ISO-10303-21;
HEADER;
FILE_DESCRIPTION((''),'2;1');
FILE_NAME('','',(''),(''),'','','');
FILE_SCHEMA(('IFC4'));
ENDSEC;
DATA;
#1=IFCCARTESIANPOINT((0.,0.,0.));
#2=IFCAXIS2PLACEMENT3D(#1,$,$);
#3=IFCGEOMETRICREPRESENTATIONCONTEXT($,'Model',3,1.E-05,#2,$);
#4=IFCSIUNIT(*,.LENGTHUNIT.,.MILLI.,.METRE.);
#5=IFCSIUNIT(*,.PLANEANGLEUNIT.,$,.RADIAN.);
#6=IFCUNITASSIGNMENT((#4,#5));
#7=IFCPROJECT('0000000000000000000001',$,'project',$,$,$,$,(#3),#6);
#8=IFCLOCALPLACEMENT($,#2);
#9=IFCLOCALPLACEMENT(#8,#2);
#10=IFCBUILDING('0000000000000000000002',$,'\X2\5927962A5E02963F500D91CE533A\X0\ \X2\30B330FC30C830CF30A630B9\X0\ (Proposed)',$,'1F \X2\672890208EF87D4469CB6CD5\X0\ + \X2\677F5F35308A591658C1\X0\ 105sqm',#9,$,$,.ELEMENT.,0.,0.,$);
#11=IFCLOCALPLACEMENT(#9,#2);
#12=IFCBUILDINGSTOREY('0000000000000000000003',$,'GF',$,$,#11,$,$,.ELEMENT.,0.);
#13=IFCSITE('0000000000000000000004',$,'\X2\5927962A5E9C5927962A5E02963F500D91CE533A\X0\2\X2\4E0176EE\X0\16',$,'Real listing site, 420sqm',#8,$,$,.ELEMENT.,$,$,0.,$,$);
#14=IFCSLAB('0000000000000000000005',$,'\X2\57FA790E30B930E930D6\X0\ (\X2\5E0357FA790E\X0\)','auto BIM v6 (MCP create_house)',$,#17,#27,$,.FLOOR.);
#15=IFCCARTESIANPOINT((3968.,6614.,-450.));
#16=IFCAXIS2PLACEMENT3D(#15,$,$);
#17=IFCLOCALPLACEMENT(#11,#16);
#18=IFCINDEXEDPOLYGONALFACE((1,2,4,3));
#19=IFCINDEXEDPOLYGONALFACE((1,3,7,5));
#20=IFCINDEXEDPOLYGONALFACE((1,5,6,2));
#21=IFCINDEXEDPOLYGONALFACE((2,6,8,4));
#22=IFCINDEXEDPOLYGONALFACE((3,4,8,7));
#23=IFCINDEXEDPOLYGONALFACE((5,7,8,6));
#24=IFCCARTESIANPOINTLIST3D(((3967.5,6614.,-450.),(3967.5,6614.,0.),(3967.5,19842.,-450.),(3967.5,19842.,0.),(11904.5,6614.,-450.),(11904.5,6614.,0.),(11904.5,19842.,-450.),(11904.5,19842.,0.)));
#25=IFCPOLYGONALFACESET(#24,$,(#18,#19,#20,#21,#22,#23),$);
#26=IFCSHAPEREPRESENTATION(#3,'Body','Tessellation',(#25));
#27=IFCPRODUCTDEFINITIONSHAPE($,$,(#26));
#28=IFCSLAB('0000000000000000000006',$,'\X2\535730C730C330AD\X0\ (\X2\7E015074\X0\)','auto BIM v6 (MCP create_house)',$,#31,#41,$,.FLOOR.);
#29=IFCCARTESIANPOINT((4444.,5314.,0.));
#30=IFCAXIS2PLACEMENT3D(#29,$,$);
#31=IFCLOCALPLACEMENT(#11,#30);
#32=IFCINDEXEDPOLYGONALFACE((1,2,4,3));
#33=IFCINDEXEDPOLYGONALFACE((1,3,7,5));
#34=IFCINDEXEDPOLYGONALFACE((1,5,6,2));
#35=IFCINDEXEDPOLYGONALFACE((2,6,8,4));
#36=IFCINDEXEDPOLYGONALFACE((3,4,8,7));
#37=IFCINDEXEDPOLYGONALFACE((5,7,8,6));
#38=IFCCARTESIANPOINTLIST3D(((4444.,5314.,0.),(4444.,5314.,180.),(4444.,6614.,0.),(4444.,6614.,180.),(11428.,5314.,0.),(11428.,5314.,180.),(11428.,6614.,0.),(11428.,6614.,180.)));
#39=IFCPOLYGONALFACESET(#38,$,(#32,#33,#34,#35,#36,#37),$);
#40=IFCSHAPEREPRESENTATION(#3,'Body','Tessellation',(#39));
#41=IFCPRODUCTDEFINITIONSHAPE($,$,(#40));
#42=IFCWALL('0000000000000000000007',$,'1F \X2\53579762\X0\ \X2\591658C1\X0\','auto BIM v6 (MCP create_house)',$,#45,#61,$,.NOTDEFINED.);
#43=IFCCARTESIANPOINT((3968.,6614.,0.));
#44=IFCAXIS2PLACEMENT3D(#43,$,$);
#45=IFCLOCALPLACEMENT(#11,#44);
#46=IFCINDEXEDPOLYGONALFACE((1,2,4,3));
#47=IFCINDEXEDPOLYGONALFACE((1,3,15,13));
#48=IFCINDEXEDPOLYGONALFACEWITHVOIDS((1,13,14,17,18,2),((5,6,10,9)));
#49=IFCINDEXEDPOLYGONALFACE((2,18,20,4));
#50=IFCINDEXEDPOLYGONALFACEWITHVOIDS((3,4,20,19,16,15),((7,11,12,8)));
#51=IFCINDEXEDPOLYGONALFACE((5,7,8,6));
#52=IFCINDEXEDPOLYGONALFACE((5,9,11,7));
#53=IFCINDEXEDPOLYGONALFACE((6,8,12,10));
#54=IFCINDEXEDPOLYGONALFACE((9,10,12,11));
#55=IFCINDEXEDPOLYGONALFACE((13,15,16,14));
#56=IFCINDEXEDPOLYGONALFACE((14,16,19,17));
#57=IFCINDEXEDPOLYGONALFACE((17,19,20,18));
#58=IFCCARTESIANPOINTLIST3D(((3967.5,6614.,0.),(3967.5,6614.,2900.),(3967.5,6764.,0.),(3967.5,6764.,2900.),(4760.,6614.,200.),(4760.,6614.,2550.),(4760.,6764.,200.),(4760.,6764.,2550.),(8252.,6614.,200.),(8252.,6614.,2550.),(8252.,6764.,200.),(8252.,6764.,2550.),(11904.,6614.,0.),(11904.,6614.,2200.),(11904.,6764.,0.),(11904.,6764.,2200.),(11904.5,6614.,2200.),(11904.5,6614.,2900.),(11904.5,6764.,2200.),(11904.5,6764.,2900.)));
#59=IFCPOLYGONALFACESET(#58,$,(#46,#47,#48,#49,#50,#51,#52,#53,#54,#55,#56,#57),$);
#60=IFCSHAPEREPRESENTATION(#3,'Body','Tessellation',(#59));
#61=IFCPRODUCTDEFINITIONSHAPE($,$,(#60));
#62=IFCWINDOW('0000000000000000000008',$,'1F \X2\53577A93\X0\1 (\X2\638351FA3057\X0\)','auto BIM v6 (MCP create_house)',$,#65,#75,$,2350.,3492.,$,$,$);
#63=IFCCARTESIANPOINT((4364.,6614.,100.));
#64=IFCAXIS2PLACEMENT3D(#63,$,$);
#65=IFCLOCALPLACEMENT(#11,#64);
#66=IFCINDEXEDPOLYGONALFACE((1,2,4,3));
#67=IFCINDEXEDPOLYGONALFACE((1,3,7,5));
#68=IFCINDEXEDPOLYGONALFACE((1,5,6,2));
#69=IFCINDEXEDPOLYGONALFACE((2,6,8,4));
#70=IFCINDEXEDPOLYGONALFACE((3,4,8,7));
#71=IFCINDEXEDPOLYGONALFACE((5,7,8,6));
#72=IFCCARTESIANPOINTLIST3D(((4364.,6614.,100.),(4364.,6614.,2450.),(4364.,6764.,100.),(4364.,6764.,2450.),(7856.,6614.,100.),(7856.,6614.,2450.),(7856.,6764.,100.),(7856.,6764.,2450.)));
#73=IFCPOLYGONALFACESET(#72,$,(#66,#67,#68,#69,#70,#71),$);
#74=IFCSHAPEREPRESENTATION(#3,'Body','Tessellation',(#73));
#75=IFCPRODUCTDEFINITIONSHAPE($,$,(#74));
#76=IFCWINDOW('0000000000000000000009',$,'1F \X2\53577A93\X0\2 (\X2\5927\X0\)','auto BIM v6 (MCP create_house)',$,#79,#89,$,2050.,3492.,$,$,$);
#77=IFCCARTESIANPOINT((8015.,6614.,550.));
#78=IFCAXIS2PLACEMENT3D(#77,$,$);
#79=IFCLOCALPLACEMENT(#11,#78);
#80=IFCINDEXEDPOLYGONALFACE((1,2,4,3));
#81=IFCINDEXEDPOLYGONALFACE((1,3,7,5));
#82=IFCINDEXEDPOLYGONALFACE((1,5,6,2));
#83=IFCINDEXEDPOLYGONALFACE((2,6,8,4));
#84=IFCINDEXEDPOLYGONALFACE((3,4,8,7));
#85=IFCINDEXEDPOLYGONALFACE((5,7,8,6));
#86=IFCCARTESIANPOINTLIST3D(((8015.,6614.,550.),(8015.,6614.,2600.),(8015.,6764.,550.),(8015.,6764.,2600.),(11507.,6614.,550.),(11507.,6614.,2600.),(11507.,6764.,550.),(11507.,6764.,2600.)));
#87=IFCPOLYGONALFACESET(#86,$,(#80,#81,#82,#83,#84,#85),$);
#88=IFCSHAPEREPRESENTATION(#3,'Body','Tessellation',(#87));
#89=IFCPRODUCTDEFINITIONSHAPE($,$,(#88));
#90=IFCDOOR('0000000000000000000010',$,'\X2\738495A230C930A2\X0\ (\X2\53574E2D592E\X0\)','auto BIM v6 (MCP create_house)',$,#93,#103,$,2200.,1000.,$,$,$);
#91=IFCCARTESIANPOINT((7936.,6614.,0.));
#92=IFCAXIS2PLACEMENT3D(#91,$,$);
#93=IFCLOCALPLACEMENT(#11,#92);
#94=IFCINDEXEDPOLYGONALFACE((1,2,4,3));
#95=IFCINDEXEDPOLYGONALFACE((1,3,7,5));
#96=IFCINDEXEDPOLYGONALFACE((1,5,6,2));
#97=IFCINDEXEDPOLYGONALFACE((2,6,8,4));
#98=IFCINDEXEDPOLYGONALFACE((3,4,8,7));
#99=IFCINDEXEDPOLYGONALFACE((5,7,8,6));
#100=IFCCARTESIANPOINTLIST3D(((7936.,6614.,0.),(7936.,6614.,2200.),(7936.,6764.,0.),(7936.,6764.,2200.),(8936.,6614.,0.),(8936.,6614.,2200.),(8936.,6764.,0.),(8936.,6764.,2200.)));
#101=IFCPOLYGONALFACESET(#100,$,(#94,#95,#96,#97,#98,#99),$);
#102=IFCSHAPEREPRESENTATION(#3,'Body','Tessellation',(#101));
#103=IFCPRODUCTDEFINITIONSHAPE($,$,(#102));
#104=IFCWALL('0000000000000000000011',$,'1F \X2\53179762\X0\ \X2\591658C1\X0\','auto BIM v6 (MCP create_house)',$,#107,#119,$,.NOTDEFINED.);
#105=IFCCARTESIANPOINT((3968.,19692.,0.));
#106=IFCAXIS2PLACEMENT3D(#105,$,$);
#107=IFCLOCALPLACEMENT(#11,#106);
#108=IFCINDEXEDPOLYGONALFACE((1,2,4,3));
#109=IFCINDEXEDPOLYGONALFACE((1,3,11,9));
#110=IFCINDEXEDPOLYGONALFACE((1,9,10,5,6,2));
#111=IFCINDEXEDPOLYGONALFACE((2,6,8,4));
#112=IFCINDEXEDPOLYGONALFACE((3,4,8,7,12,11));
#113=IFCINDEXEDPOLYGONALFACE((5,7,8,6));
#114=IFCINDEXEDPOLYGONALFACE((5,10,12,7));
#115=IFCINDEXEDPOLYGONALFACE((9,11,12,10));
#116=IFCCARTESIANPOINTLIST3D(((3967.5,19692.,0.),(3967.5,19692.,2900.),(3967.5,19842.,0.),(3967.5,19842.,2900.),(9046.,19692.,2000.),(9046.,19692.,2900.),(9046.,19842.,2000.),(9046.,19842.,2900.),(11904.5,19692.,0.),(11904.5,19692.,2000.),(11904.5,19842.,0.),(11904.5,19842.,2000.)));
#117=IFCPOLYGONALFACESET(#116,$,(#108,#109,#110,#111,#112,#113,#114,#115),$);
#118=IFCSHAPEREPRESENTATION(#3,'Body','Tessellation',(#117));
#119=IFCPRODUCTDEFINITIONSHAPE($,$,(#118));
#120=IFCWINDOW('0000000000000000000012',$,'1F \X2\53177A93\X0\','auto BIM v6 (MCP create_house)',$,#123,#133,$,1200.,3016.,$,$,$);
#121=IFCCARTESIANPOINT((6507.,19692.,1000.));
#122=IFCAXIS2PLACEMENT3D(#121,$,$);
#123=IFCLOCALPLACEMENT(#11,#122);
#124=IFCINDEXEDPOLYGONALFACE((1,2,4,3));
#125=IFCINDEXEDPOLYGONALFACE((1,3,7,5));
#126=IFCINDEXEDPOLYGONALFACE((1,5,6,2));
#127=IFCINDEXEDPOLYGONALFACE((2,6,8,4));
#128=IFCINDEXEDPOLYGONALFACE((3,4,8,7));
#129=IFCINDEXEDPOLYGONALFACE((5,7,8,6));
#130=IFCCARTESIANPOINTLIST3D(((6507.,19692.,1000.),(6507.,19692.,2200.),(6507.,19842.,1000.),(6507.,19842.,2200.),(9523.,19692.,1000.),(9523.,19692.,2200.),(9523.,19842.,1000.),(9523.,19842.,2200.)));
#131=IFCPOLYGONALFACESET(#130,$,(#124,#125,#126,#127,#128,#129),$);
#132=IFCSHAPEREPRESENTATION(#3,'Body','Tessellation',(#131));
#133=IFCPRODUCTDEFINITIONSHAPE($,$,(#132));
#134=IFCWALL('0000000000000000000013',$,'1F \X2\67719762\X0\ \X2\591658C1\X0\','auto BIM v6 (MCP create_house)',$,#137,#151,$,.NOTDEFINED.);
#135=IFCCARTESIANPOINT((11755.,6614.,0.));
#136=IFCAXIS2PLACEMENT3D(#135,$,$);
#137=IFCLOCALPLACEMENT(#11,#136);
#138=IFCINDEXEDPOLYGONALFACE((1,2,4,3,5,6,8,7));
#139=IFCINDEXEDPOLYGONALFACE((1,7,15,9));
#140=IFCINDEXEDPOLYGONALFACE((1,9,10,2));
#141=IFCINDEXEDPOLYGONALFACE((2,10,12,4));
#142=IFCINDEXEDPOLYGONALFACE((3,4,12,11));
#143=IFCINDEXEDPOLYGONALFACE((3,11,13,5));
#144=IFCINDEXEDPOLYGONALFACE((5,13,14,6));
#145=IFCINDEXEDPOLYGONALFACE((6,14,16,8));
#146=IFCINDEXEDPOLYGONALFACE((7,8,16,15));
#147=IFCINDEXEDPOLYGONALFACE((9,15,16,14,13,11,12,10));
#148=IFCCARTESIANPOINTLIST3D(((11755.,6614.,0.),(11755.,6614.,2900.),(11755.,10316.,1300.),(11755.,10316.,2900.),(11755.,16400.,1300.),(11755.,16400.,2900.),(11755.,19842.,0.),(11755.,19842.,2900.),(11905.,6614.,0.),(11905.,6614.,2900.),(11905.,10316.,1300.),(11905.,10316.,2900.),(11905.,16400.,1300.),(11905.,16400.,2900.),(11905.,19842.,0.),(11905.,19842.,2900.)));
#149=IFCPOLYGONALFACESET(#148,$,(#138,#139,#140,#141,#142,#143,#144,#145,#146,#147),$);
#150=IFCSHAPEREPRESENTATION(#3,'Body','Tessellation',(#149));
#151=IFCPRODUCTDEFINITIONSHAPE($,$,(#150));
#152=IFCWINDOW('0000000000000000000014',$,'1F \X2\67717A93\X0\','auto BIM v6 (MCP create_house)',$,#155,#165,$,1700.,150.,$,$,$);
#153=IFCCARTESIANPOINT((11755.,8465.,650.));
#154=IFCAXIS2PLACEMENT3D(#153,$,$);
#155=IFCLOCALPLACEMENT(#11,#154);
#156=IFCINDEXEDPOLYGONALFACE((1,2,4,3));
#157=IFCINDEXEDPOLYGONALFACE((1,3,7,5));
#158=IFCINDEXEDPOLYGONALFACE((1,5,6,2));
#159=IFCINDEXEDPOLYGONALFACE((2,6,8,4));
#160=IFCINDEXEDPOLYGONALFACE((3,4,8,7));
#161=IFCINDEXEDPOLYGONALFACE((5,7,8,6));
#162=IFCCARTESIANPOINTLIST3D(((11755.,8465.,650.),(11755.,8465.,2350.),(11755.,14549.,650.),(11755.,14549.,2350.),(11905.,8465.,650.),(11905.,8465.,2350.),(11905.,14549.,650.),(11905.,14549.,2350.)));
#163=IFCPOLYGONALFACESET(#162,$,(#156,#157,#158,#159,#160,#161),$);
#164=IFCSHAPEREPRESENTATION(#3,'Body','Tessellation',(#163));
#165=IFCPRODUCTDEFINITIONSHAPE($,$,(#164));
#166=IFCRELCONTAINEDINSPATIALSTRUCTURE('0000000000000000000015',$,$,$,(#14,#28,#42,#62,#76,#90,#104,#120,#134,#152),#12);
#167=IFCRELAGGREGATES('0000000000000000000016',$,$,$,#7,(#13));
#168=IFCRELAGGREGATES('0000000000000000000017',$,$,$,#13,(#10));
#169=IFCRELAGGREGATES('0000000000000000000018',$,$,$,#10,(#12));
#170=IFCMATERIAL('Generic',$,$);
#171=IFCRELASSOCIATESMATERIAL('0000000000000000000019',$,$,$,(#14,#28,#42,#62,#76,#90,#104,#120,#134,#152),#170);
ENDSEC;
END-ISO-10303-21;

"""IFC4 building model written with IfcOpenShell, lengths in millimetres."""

from ifc_helpers import new_model, si_unit, frame, frame_2d, origin, place, context, project, spatial, rectangle, extrude, material, element, fill, save


model = new_model("IFC4")

# Units and contexts
model_context = context("Model", 3, precision=1e-05, world=origin())
ifc_project = project(units=[si_unit("LENGTHUNIT", "METRE", prefix="MILLI"), si_unit("PLANEANGLEUNIT", "RADIAN")], contexts=[model_context])

# Site, building, storey
site_placement = place(None, origin())
site = spatial("IfcSite", under=ifc_project, at=site_placement, Name="大阪府大阪市阿倍野区2丁目16", ObjectType="Real listing site, 420sqm", CompositionType="ELEMENT", RefElevation=0.0)
building_placement = place(site_placement, origin())
building = spatial("IfcBuilding", under=site, at=building_placement, Name="大阪市阿倍野区 コートハウス (Proposed)", ObjectType="1F 木造軸組構法 + 板張り外壁 105sqm", CompositionType="ELEMENT", ElevationOfRefHeight=0.0, ElevationOfTerrain=0.0)
storey_placement = place(building_placement, origin())
storey = spatial("IfcBuildingStorey", under=building, at=storey_placement, Name="GF", CompositionType="ELEMENT", Elevation=0.0)

# Slabs
ifc_material = material(Name="Generic")
slab_1_placement = place(storey_placement, frame((3968.0, 6614.0, -450.0)))
element("IfcSlab", 1, at=slab_1_placement, inside=storey, material=ifc_material, Name="基礎スラブ (布基礎)", Description="auto BIM v6 (MCP create_house)", PredefinedType="FLOOR", context=model_context, shape_type="SweptSolid", body=[
    extrude(rectangle(XDim=7937.0, YDim=13228.0, at=frame_2d((3968.0, 6614.0))), frame((3968.0, 6614.0, -450.0)), (0.0, 0.0, 1.0), 450.0),
])
slab_2_placement = place(storey_placement, frame((4444.0, 5314.0, 0.0)))
element("IfcSlab", 2, at=slab_2_placement, inside=storey, material=ifc_material, Name="南デッキ (縁側)", Description="auto BIM v6 (MCP create_house)", PredefinedType="FLOOR", context=model_context, shape_type="SweptSolid", body=[
    extrude(rectangle(XDim=6984.0, YDim=1300.0, at=frame_2d((3492.0, 650.0))), frame((4444.0, 5314.0, 0.0)), (0.0, 0.0, 1.0), 180.0),
])

# Wall, openings, windows, door
wall_1_placement = place(storey_placement, frame((3968.0, 6614.0, 0.0)))
wall_1 = element("IfcWall", 3, at=wall_1_placement, inside=storey, material=ifc_material, Name="1F 南面 外壁", Description="auto BIM v6 (MCP create_house)", PredefinedType="NOTDEFINED", context=model_context, shape_type="SweptSolid", body=[
    extrude(rectangle(XDim=7937.0, YDim=150.0, at=frame_2d((3968.0, 75.0))), frame((3968.0, 6614.0, 0.0)), (0.0, 0.0, 1.0), 2900.0),
])
opening_1_placement = place(storey_placement, frame((4364.0, 6614.0, 100.0)))
opening_1 = element("IfcOpeningElement", 4, at=opening_1_placement, cuts=wall_1, PredefinedType="NOTDEFINED", context=model_context, shape_type="SweptSolid", body=[
    extrude(rectangle(XDim=3492.0, YDim=150.0, at=frame_2d((1746.0, 75.0))), frame((4364.0, 6614.0, 100.0)), (0.0, 0.0, 1.0), 2350.0),
])
opening_2_placement = place(storey_placement, frame((8015.0, 6614.0, 550.0)))
opening_2 = element("IfcOpeningElement", 5, at=opening_2_placement, cuts=wall_1, PredefinedType="NOTDEFINED", context=model_context, shape_type="SweptSolid", body=[
    extrude(rectangle(XDim=3492.0, YDim=150.0, at=frame_2d((1746.0, 75.0))), frame((8015.0, 6614.0, 550.0)), (0.0, 0.0, 1.0), 2050.0),
])
opening_3_placement = place(storey_placement, frame((7936.0, 6614.0, 0.0)))
opening_3 = element("IfcOpeningElement", 6, at=opening_3_placement, cuts=wall_1, PredefinedType="NOTDEFINED", context=model_context, shape_type="SweptSolid", body=[
    extrude(rectangle(XDim=1000.0, YDim=150.0, at=frame_2d((500.0, 75.0))), frame((7936.0, 6614.0, 0.0)), (0.0, 0.0, 1.0), 2200.0),
])
window_1_placement = place(storey_placement, frame((4364.0, 6614.0, 100.0)))
window_1 = element("IfcWindow", 7, at=window_1_placement, inside=storey, material=ifc_material, Name="1F 南窓1 (掃出し)", Description="auto BIM v6 (MCP create_house)", OverallHeight=2350.0, OverallWidth=3492.0, context=model_context, shape_type="SweptSolid", body=[
    extrude(rectangle(XDim=3492.0, YDim=150.0, at=frame_2d((1746.0, 75.0))), frame((4364.0, 6614.0, 100.0)), (0.0, 0.0, 1.0), 2350.0),
])
fill(opening_1, window_1)
window_2_placement = place(storey_placement, frame((8015.0, 6614.0, 550.0)))
window_2 = element("IfcWindow", 8, at=window_2_placement, inside=storey, material=ifc_material, Name="1F 南窓2 (大)", Description="auto BIM v6 (MCP create_house)", OverallHeight=2050.0, OverallWidth=3492.0, context=model_context, shape_type="SweptSolid", body=[
    extrude(rectangle(XDim=3492.0, YDim=150.0, at=frame_2d((1746.0, 75.0))), frame((8015.0, 6614.0, 550.0)), (0.0, 0.0, 1.0), 2050.0),
])
fill(opening_2, window_2)
door_placement = place(storey_placement, frame((7936.0, 6614.0, 0.0)))
door = element("IfcDoor", 9, at=door_placement, inside=storey, material=ifc_material, Name="玄関ドア (南中央)", Description="auto BIM v6 (MCP create_house)", OverallHeight=2200.0, OverallWidth=1000.0, context=model_context, shape_type="SweptSolid", body=[
    extrude(rectangle(XDim=1000.0, YDim=150.0, at=frame_2d((500.0, 75.0))), frame((7936.0, 6614.0, 0.0)), (0.0, 0.0, 1.0), 2200.0),
])
fill(opening_3, door)

# Walls, openings, windows
wall_2_placement = place(storey_placement, frame((3968.0, 19692.0, 0.0)))
wall_2 = element("IfcWall", 10, at=wall_2_placement, inside=storey, material=ifc_material, Name="1F 北面 外壁", Description="auto BIM v6 (MCP create_house)", PredefinedType="NOTDEFINED", context=model_context, shape_type="SweptSolid", body=[
    extrude(rectangle(XDim=7937.0, YDim=150.0, at=frame_2d((3968.0, 75.0))), frame((3968.0, 19692.0, 0.0)), (0.0, 0.0, 1.0), 2900.0),
])
opening_4_placement = place(storey_placement, frame((6507.0, 19692.0, 1000.0)))
opening_4 = element("IfcOpeningElement", 11, at=opening_4_placement, cuts=wall_2, PredefinedType="NOTDEFINED", context=model_context, shape_type="SweptSolid", body=[
    extrude(rectangle(XDim=3016.0, YDim=150.0, at=frame_2d((1508.0, 75.0))), frame((6507.0, 19692.0, 1000.0)), (0.0, 0.0, 1.0), 1200.0),
])
window_3_placement = place(storey_placement, frame((6507.0, 19692.0, 1000.0)))
window_3 = element("IfcWindow", 12, at=window_3_placement, inside=storey, material=ifc_material, Name="1F 北窓", Description="auto BIM v6 (MCP create_house)", OverallHeight=1200.0, OverallWidth=3016.0, context=model_context, shape_type="SweptSolid", body=[
    extrude(rectangle(XDim=3016.0, YDim=150.0, at=frame_2d((1508.0, 75.0))), frame((6507.0, 19692.0, 1000.0)), (0.0, 0.0, 1.0), 1200.0),
])
fill(opening_4, window_3)
wall_3_placement = place(storey_placement, frame((11755.0, 6614.0, 0.0)))
wall_3 = element("IfcWall", 13, at=wall_3_placement, inside=storey, material=ifc_material, Name="1F 東面 外壁", Description="auto BIM v6 (MCP create_house)", PredefinedType="NOTDEFINED", context=model_context, shape_type="SweptSolid", body=[
    extrude(rectangle(XDim=150.0, YDim=13228.0, at=frame_2d((75.0, 6614.0))), frame((11755.0, 6614.0, 0.0)), (0.0, 0.0, 1.0), 2900.0),
])
opening_5_placement = place(storey_placement, frame((11755.0, 8465.0, 650.0)))
opening_5 = element("IfcOpeningElement", 14, at=opening_5_placement, cuts=wall_3, PredefinedType="NOTDEFINED", context=model_context, shape_type="SweptSolid", body=[
    extrude(rectangle(XDim=150.0, YDim=6084.0, at=frame_2d((75.0, 3042.0))), frame((11755.0, 8465.0, 650.0)), (0.0, 0.0, 1.0), 1700.0),
])
window_4_placement = place(storey_placement, frame((11755.0, 8465.0, 650.0)))
window_4 = element("IfcWindow", 15, at=window_4_placement, inside=storey, material=ifc_material, Name="1F 東窓", Description="auto BIM v6 (MCP create_house)", OverallHeight=1700.0, OverallWidth=150.0, context=model_context, shape_type="SweptSolid", body=[
    extrude(rectangle(XDim=150.0, YDim=6084.0, at=frame_2d((75.0, 3042.0))), frame((11755.0, 8465.0, 650.0)), (0.0, 0.0, 1.0), 1700.0),
])
fill(opening_5, window_4)

save(model, "model.ifc")
